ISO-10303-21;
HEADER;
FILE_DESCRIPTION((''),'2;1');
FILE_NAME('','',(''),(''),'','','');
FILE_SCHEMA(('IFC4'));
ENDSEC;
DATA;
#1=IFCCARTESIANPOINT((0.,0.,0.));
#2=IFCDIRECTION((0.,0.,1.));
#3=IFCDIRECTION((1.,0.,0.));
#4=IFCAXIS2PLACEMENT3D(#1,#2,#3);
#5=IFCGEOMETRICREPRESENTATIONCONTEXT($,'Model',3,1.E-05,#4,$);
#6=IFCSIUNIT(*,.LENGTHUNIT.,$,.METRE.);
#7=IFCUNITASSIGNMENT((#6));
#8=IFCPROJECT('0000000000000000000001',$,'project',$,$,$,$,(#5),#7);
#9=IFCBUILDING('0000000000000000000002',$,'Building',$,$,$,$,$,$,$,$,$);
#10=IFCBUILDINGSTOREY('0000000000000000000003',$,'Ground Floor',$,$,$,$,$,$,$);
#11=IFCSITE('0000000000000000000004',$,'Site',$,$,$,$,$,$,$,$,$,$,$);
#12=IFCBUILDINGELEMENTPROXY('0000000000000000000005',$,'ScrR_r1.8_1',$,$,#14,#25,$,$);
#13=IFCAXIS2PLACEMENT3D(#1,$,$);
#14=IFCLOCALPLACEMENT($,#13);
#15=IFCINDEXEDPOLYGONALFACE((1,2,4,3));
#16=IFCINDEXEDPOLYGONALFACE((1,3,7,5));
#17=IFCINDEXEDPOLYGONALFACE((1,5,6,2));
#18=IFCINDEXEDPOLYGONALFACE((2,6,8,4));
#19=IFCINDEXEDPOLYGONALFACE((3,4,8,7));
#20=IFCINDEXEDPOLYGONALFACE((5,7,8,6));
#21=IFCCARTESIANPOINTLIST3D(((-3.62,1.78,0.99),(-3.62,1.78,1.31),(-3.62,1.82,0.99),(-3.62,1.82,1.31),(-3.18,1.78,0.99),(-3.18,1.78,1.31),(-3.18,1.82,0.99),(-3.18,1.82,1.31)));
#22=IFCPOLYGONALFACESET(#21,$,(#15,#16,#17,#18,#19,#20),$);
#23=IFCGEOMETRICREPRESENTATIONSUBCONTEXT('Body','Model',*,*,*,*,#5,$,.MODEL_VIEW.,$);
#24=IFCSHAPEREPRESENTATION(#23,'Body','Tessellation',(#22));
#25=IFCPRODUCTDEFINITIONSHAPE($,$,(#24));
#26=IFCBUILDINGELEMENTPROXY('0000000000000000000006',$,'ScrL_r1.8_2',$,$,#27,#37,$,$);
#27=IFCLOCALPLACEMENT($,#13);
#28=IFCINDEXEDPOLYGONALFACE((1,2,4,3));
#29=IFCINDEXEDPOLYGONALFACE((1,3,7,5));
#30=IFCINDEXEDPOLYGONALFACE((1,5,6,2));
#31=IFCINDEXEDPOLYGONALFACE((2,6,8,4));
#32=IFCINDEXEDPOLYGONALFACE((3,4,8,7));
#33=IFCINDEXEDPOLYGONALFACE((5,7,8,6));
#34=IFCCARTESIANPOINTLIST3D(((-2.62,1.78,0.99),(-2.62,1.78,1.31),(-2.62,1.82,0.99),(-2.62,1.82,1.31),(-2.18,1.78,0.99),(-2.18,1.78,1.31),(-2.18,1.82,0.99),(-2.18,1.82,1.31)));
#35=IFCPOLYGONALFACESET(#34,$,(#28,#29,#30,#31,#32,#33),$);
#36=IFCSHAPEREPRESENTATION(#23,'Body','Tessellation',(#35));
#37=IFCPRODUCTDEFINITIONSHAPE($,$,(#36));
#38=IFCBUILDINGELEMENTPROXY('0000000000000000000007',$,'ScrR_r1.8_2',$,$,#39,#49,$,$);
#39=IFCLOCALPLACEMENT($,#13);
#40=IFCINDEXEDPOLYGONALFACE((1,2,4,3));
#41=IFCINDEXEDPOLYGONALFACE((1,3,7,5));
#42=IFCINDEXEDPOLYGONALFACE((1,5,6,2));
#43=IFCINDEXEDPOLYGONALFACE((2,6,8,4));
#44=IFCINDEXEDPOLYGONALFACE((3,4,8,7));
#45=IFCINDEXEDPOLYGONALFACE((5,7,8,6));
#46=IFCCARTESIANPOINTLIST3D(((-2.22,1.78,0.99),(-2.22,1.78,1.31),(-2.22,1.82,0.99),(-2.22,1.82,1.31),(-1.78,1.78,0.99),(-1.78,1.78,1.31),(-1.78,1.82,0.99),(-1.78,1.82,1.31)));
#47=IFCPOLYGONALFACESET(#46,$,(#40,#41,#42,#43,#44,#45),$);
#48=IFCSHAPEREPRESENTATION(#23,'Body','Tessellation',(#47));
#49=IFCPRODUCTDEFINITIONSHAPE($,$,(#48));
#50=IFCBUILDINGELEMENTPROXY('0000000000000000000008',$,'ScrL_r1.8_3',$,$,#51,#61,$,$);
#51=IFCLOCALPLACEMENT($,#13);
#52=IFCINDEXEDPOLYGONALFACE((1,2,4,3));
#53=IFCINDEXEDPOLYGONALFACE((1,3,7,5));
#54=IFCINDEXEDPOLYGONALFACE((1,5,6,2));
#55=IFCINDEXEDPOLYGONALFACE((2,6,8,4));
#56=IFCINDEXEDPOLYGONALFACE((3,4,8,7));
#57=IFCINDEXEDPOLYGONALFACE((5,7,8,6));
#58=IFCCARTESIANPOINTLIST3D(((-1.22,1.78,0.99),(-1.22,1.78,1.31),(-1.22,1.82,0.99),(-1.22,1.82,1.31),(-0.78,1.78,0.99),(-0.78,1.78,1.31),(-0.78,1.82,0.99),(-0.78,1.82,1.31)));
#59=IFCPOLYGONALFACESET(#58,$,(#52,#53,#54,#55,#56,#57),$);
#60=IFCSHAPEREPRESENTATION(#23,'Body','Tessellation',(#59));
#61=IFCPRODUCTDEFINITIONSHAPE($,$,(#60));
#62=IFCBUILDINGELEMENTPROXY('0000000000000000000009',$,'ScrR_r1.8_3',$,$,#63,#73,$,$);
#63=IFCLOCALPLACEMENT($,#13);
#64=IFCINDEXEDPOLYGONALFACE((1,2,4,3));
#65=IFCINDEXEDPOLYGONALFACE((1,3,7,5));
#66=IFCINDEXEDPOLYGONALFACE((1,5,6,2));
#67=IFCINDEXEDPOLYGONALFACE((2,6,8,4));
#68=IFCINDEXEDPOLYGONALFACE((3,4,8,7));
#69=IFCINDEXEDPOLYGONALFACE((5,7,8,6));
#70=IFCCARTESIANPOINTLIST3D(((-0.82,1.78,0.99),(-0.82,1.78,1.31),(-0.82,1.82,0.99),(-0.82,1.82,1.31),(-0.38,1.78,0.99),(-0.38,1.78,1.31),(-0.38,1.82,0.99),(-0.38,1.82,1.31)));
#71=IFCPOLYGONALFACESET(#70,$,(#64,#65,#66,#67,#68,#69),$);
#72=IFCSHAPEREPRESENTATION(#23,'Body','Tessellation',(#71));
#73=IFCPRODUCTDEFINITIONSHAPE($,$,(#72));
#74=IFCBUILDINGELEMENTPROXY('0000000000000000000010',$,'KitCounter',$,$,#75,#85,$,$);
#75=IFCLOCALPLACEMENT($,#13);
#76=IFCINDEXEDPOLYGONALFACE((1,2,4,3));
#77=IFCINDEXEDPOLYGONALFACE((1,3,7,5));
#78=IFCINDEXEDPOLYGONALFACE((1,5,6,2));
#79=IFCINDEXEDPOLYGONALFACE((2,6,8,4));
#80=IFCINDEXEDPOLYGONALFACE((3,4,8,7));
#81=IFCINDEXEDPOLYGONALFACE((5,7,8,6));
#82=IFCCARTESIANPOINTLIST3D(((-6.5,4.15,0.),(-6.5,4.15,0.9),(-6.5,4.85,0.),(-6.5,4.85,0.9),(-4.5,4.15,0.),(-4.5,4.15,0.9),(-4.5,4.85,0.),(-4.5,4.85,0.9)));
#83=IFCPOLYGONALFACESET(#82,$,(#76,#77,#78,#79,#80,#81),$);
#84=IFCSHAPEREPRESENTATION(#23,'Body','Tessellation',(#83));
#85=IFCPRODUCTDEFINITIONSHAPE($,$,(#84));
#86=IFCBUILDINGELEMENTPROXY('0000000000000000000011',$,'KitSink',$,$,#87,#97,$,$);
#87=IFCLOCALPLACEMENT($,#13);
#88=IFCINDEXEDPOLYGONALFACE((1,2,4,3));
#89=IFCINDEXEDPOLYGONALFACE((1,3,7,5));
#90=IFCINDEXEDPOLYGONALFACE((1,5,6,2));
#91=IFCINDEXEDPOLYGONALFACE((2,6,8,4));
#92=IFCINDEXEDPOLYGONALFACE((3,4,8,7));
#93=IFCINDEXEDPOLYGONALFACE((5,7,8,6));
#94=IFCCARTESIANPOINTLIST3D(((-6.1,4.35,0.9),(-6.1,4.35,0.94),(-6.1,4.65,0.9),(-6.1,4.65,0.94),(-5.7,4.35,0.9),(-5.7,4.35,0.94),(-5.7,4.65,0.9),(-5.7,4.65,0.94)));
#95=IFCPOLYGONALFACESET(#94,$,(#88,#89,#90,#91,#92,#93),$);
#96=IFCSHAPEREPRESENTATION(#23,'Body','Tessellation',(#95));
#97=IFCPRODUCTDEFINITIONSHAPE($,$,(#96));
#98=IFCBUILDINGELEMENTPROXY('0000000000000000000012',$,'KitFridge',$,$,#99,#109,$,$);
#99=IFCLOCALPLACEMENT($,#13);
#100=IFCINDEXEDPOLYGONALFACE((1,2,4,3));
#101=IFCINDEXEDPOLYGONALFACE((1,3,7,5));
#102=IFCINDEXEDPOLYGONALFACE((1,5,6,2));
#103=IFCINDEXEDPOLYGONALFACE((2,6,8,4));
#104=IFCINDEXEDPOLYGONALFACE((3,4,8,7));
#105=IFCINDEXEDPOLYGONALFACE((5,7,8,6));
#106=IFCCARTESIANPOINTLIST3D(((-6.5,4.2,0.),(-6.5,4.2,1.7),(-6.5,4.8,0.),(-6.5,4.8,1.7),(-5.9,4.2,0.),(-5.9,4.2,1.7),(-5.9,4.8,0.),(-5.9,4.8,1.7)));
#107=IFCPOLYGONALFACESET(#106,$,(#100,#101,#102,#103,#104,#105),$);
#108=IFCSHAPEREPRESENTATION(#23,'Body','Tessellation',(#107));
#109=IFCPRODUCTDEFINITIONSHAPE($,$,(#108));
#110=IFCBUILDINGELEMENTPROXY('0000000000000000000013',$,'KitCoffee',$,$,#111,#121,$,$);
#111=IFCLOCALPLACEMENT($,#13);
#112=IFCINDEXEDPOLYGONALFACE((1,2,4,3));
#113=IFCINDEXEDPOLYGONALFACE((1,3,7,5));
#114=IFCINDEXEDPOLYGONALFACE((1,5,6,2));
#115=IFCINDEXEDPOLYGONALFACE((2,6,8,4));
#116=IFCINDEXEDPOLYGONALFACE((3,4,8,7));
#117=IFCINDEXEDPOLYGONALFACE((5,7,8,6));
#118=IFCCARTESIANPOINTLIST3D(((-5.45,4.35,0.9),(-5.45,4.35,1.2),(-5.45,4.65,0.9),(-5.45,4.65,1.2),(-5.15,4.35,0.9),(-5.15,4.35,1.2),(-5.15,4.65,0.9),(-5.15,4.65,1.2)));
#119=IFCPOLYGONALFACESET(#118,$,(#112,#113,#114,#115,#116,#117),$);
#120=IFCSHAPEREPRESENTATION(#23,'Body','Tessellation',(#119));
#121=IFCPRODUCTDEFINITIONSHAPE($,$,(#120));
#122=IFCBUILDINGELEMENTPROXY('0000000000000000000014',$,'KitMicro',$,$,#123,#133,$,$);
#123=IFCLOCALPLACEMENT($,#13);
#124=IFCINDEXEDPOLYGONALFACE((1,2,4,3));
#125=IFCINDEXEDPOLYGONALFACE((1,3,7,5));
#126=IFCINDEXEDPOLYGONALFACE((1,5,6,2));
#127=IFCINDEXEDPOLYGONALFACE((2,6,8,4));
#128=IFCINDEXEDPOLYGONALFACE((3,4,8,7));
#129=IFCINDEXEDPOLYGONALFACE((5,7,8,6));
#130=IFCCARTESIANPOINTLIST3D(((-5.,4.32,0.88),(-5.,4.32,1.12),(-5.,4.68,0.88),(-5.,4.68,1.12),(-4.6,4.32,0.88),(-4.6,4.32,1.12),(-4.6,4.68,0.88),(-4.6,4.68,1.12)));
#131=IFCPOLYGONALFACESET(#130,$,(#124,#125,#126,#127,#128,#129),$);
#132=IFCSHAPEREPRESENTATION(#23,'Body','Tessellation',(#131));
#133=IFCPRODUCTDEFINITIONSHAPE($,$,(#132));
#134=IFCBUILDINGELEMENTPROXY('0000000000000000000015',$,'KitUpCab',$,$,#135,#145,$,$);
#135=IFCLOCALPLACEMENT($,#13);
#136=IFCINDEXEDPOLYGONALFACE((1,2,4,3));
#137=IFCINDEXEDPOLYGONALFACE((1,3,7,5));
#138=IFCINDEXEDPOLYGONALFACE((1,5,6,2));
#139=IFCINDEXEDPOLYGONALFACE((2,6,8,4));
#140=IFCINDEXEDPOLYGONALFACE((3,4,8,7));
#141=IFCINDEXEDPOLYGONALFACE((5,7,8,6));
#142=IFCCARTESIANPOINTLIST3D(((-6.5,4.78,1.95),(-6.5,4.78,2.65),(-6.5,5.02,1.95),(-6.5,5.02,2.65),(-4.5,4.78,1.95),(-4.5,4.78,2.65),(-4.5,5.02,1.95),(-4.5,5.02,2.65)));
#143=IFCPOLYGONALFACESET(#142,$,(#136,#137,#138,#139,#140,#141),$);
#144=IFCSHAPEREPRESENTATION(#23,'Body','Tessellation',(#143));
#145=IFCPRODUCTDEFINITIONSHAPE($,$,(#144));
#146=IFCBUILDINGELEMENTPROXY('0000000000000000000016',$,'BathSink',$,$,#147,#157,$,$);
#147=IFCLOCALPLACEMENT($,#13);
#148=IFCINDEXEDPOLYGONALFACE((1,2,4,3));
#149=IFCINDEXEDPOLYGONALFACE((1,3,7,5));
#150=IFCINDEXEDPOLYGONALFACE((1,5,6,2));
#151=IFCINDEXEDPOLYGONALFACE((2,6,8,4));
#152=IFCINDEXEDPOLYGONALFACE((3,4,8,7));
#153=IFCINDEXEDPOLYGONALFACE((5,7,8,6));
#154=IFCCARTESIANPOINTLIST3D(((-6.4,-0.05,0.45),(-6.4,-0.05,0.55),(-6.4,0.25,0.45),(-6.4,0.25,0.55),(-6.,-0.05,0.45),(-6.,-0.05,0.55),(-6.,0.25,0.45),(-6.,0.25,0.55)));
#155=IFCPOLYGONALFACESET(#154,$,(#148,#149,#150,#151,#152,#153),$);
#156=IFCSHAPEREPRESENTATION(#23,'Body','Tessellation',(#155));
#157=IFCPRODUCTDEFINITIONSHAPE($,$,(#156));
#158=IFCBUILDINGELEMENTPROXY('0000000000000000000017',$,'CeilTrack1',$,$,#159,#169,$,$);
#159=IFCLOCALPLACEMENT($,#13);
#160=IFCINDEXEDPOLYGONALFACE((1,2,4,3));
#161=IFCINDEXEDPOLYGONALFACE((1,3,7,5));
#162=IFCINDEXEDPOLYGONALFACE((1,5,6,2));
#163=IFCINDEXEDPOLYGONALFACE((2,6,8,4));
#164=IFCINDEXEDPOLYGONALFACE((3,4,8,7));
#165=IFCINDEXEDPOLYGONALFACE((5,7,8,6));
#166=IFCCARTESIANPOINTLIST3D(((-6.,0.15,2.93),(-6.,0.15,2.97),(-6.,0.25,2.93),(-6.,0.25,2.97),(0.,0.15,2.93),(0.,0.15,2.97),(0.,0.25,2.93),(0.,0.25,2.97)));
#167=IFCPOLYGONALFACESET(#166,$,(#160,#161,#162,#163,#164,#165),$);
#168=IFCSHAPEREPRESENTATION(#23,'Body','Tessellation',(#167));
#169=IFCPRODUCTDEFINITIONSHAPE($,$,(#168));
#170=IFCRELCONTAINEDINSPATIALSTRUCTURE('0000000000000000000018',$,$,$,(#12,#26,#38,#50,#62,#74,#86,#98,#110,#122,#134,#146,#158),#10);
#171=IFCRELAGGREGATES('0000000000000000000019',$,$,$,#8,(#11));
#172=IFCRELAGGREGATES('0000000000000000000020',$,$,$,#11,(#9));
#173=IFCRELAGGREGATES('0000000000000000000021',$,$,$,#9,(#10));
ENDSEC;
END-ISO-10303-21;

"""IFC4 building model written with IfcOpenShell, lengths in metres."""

from ifc_helpers import new_model, si_unit, frame, origin_with_axes, origin_2d, place, context, subcontext, project, spatial, rectangle, extrude, element, save


model = new_model("IFC4")

# Units and contexts
model_context = context("Model", 3, precision=1e-05, world=origin_with_axes())
body_context = subcontext(model_context, "Body", "Model", "MODEL_VIEW")
ifc_project = project(units=[si_unit("LENGTHUNIT", "METRE")], contexts=[model_context])

# Site, building, storey
site = spatial("IfcSite", under=ifc_project, Name="Site")
building = spatial("IfcBuilding", under=site, Name="Building")
storey = spatial("IfcBuildingStorey", under=building, Name="Ground Floor")

# Building element proxies
for number, where, z_axis, x_axis, name in (
    (1, (-3.4, 1.8, 1.15), (0.0, 0.0, 1.0), (1.0, 0.0, 0.0), "ScrR_r1.8_1"),
    (2, (-2.4, 1.8, 1.15), (0.0, 0.0, 1.0), (1.0, 0.0, 0.0), "ScrL_r1.8_2"),
    (3, (-2.0, 1.8, 1.15), (0.0, 0.0, 1.0), (1.0, 0.0, 0.0), "ScrR_r1.8_2"),
    (4, (-1.0, 1.8, 1.15), (0.0, 0.0, 1.0), (1.0, 0.0, 0.0), "ScrL_r1.8_3"),
    (5, (-0.6, 1.8, 1.15), (0.0, 0.0, 1.0), (1.0, 0.0, 0.0), "ScrR_r1.8_3"),
):
    element("IfcBuildingElementProxy", number, at=place(None, frame(where, z_axis=z_axis, x_axis=x_axis)), inside=storey, Name=name, context=body_context, shape_type="SweptSolid", body=[
        extrude(rectangle(XDim=0.44, YDim=0.04, at=origin_2d()), frame((0.0, 0.0, -0.16)), (0.0, 0.0, 1.0), 0.32),
    ])
proxy_1_placement = place(None, frame((-5.5, 4.5, 0.45), z_axis=(0.0, 0.0, 1.0), x_axis=(1.0, 0.0, 0.0)))
element("IfcBuildingElementProxy", 6, at=proxy_1_placement, inside=storey, Name="KitCounter", context=body_context, shape_type="SweptSolid", body=[
    extrude(rectangle(XDim=2.0, YDim=0.7, at=origin_2d()), frame((0.0, 0.0, -0.45)), (0.0, 0.0, 1.0), 0.9),
])
proxy_2_placement = place(None, frame((-5.9, 4.5, 0.92), z_axis=(0.0, 0.0, 1.0), x_axis=(1.0, 0.0, 0.0)))
element("IfcBuildingElementProxy", 7, at=proxy_2_placement, inside=storey, Name="KitSink", context=body_context, shape_type="SweptSolid", body=[
    extrude(rectangle(XDim=0.4, YDim=0.3, at=origin_2d()), frame((0.0, 0.0, -0.02)), (0.0, 0.0, 1.0), 0.04),
])
proxy_3_placement = place(None, frame((-6.2, 4.5, 0.85), z_axis=(0.0, 0.0, 1.0), x_axis=(1.0, 0.0, 0.0)))
element("IfcBuildingElementProxy", 8, at=proxy_3_placement, inside=storey, Name="KitFridge", context=body_context, shape_type="SweptSolid", body=[
    extrude(rectangle(XDim=0.6, YDim=0.6, at=origin_2d()), frame((0.0, 0.0, -0.85)), (0.0, 0.0, 1.0), 1.7),
])
proxy_4_placement = place(None, frame((-5.3, 4.5, 1.05), z_axis=(0.0, 0.0, 1.0), x_axis=(1.0, 0.0, 0.0)))
element("IfcBuildingElementProxy", 9, at=proxy_4_placement, inside=storey, Name="KitCoffee", context=body_context, shape_type="SweptSolid", body=[
    extrude(rectangle(XDim=0.3, YDim=0.3, at=origin_2d()), frame((0.0, 0.0, -0.15)), (0.0, 0.0, 1.0), 0.3),
])
proxy_5_placement = place(None, frame((-4.8, 4.5, 1.0), z_axis=(0.0, 0.0, 1.0), x_axis=(1.0, 0.0, 0.0)))
element("IfcBuildingElementProxy", 10, at=proxy_5_placement, inside=storey, Name="KitMicro", context=body_context, shape_type="SweptSolid", body=[
    extrude(rectangle(XDim=0.4, YDim=0.36, at=origin_2d()), frame((0.0, 0.0, -0.12)), (0.0, 0.0, 1.0), 0.24),
])
proxy_6_placement = place(None, frame((-5.5, 4.9, 2.3), z_axis=(0.0, 0.0, 1.0), x_axis=(1.0, 0.0, 0.0)))
element("IfcBuildingElementProxy", 11, at=proxy_6_placement, inside=storey, Name="KitUpCab", context=body_context, shape_type="SweptSolid", body=[
    extrude(rectangle(XDim=2.0, YDim=0.24, at=origin_2d()), frame((0.0, 0.0, -0.35)), (0.0, 0.0, 1.0), 0.7),
])
proxy_7_placement = place(None, frame((-6.2, 0.1, 0.5), z_axis=(0.0, 0.0, 1.0), x_axis=(1.0, 0.0, 0.0)))
element("IfcBuildingElementProxy", 12, at=proxy_7_placement, inside=storey, Name="BathSink", context=body_context, shape_type="SweptSolid", body=[
    extrude(rectangle(XDim=0.4, YDim=0.3, at=origin_2d()), frame((0.0, 0.0, -0.05)), (0.0, 0.0, 1.0), 0.1),
])
proxy_8_placement = place(None, frame((-3.0, 0.2, 2.95), z_axis=(0.0, 0.0, 1.0), x_axis=(1.0, 0.0, 0.0)))
element("IfcBuildingElementProxy", 13, at=proxy_8_placement, inside=storey, Name="CeilTrack1", context=body_context, shape_type="SweptSolid", body=[
    extrude(rectangle(XDim=6.0, YDim=0.1, at=origin_2d()), frame((0.0, 0.0, -0.02)), (0.0, 0.0, 1.0), 0.04),
])

save(model, "model.ifc")
